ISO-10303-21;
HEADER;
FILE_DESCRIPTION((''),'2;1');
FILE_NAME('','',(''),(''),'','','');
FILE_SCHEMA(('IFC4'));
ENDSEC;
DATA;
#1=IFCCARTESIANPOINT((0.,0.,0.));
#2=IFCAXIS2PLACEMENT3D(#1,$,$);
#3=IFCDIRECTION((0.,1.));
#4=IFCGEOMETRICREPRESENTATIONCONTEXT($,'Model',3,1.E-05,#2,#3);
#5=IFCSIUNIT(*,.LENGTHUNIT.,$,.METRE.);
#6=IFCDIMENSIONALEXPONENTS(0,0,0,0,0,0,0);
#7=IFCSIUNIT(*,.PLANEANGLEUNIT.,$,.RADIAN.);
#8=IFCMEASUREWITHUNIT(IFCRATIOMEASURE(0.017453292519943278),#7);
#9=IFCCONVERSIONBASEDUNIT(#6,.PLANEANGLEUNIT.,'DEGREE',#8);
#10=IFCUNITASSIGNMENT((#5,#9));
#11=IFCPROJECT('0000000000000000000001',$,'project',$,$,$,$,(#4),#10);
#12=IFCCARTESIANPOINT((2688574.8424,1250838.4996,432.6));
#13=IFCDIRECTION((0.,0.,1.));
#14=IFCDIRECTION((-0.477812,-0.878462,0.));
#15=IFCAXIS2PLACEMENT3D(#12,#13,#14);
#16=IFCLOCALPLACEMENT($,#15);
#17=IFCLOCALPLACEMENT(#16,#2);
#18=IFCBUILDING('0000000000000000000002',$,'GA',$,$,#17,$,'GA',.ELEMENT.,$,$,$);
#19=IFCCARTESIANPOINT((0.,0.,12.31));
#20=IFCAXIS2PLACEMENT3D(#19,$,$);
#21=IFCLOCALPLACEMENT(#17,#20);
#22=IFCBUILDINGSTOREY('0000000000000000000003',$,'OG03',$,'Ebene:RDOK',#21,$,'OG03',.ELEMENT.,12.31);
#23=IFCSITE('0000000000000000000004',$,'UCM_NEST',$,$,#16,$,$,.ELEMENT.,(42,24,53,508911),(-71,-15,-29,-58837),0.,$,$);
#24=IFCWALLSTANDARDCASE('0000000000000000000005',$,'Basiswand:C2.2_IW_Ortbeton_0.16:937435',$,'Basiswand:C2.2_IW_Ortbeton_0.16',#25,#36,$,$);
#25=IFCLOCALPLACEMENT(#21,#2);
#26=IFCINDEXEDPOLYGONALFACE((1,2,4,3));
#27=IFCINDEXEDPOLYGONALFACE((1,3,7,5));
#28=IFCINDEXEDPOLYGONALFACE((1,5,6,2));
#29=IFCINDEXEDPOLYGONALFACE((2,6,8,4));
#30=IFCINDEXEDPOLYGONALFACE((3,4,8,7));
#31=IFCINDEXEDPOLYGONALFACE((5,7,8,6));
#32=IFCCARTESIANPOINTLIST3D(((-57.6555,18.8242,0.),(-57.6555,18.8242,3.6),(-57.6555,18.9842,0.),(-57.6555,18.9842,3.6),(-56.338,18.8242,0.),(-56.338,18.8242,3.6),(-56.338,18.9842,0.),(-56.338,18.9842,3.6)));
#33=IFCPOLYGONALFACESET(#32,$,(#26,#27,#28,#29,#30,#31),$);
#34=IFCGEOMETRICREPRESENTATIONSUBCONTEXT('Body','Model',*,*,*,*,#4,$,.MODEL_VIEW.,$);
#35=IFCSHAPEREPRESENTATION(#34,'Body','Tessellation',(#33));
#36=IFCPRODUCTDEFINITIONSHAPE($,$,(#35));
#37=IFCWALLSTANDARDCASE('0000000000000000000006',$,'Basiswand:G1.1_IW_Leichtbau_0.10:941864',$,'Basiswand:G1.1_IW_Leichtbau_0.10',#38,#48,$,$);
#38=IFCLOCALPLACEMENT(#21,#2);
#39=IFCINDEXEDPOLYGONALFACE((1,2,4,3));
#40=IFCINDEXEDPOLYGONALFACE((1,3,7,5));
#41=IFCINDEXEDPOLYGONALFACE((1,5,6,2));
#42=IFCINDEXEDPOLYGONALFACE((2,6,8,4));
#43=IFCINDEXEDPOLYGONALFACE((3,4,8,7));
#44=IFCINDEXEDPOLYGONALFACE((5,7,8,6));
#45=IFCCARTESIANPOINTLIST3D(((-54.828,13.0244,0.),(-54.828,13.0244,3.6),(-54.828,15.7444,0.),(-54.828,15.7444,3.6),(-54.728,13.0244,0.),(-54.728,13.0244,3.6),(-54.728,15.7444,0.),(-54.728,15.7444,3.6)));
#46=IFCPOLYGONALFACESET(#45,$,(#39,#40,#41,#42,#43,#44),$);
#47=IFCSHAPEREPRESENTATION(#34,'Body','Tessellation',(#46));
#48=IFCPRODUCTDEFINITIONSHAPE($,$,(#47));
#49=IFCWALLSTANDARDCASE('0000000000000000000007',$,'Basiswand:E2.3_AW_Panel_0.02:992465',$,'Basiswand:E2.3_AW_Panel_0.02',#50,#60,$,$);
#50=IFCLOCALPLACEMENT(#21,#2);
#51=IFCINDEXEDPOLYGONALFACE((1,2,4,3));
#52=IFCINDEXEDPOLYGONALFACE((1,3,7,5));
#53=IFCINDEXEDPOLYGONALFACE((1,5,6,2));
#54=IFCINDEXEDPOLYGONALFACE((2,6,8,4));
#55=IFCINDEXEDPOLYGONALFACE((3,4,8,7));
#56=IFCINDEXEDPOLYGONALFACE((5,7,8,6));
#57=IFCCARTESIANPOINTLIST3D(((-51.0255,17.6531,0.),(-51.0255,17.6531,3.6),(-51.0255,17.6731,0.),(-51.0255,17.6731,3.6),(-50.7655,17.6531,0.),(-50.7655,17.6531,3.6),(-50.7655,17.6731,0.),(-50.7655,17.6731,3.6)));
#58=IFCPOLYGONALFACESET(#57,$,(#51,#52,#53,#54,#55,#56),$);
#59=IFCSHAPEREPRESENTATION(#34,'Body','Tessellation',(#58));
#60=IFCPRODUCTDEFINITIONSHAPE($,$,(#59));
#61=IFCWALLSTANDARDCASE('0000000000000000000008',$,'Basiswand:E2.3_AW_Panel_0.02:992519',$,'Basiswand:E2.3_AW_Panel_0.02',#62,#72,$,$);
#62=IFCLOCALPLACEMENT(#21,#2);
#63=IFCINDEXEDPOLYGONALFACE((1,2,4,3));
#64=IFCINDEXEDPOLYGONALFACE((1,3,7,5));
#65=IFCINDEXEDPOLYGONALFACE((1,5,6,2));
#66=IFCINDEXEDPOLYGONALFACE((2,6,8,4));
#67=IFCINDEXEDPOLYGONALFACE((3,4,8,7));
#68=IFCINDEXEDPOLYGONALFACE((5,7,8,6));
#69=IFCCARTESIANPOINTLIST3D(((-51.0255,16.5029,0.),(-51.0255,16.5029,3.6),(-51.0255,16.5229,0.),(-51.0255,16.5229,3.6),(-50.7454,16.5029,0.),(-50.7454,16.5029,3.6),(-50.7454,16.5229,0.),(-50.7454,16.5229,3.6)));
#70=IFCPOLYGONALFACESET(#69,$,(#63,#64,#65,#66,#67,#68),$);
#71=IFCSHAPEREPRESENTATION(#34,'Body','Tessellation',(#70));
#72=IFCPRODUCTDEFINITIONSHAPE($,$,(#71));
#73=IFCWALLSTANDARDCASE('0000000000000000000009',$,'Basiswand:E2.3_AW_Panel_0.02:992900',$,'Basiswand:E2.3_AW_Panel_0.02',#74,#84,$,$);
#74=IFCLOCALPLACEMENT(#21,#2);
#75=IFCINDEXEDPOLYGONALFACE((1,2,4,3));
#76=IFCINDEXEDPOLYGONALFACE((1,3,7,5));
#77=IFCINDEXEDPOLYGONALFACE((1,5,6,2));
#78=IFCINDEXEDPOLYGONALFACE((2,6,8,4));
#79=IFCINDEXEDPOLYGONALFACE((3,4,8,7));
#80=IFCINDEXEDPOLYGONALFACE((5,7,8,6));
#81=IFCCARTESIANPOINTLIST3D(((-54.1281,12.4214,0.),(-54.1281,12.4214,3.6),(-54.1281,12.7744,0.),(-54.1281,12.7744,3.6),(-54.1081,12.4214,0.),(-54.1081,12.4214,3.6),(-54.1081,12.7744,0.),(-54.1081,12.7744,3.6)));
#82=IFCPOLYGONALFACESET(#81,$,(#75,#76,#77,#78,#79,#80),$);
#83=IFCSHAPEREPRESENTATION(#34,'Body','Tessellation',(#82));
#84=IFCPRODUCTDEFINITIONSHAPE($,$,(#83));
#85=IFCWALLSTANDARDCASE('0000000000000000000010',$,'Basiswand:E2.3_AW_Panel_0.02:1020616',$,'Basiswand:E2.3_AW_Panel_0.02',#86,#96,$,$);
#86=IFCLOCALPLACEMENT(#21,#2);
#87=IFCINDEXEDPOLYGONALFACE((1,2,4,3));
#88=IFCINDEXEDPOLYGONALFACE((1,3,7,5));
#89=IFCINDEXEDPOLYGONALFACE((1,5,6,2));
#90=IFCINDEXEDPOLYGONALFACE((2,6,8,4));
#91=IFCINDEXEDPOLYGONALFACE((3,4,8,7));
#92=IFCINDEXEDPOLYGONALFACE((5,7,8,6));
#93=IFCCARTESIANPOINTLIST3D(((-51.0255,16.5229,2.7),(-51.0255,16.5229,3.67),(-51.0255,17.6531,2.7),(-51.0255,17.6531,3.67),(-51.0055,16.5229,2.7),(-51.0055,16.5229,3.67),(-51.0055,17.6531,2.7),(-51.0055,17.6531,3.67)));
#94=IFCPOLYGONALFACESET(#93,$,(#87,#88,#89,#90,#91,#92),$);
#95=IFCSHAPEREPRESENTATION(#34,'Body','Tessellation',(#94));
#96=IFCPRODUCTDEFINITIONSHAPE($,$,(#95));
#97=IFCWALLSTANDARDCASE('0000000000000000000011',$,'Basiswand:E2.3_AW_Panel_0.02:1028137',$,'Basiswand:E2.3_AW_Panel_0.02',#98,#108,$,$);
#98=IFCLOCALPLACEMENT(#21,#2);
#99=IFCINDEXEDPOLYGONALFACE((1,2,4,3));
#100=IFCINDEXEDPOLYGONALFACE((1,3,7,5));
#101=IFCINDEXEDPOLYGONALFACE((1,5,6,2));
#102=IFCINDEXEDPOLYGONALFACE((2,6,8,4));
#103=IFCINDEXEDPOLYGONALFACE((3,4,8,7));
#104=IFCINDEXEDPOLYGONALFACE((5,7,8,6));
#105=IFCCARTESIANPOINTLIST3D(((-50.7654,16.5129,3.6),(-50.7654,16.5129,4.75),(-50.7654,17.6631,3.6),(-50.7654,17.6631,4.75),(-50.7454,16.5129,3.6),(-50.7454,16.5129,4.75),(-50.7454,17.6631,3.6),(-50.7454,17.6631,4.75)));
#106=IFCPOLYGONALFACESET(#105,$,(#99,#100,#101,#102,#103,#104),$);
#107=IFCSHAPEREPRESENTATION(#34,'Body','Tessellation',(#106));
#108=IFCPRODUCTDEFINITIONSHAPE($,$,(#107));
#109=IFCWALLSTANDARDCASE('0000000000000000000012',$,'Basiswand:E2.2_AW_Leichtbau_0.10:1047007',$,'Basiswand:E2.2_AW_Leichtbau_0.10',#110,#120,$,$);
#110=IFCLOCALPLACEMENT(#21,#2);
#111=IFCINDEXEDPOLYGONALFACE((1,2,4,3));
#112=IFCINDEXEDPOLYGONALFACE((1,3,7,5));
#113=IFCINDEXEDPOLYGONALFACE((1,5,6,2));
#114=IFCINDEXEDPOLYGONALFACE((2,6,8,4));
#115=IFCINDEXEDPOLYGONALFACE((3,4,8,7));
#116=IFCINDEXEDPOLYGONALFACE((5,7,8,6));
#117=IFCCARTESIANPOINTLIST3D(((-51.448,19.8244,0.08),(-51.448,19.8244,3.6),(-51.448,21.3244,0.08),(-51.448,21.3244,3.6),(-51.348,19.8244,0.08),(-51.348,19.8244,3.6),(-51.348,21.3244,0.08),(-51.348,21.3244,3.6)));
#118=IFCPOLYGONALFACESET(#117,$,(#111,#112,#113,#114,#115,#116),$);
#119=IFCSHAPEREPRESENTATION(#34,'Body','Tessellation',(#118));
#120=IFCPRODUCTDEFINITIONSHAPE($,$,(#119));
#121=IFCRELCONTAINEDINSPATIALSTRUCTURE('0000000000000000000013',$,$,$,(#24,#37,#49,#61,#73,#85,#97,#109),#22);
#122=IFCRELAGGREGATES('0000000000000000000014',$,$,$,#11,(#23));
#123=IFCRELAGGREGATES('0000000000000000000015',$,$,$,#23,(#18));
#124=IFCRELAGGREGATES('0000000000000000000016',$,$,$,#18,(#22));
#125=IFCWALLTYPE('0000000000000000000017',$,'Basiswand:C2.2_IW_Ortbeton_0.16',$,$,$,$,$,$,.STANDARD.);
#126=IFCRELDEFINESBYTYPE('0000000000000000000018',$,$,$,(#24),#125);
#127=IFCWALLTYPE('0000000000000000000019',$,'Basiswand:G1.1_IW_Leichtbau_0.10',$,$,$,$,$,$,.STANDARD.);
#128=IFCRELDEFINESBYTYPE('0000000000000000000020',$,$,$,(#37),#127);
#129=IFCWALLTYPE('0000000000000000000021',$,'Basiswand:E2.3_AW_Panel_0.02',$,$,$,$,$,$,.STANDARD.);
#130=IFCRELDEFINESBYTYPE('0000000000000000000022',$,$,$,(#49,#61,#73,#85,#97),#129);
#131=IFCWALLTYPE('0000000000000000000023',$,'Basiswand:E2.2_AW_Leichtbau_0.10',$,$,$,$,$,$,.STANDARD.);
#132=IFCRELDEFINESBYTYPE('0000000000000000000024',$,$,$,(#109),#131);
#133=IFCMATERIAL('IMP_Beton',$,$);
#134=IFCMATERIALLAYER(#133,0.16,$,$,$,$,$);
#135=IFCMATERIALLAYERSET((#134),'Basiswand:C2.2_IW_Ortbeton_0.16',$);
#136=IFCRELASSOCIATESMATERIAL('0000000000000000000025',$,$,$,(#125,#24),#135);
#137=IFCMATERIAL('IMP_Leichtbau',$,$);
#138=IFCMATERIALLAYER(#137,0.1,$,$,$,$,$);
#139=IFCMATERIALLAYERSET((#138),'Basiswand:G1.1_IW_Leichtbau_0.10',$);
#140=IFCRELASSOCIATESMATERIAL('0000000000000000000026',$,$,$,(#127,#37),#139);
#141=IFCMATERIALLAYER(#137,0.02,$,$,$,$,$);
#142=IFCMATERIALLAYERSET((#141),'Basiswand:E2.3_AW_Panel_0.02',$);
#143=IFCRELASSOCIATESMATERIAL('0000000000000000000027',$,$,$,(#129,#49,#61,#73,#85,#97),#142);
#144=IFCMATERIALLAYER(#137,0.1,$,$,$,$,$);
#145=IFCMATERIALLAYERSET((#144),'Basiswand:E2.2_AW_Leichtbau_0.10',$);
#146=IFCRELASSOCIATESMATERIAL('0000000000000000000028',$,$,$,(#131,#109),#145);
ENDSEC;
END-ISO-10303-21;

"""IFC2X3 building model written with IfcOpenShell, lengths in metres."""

from ifc_helpers import new_model, entity, si_unit, converted_unit, direction, frame, frame_2d, origin, place, context, subcontext, project, spatial, polyline, rectangle, extrude, clip, bounded_halfspace, material, layer, layer_set, layer_usage, type_object, element, save


model = new_model("IFC2X3")

# Units and contexts
model_context = context("Model", 3, precision=1e-05, world=origin(), true_north=direction((0.0, 1.0)))
body_context = subcontext(model_context, "Body", "Model", "MODEL_VIEW")
ifc_project = project(units=[si_unit("LENGTHUNIT", "METRE"), converted_unit("PLANEANGLEUNIT", "DEGREE", entity("IfcRatioMeasure", 0.017453292519943278), si_unit("PLANEANGLEUNIT", "RADIAN"), dimensions=[0, 0, 0, 0, 0, 0, 0])], contexts=[model_context])

# Site, building, storey
site_placement = place(None, frame((2688574.8424, 1250838.4996, 432.6), z_axis=(0.0, 0.0, 1.0), x_axis=(-0.477812, -0.878462, 0.0)))
site = spatial("IfcSite", under=ifc_project, at=site_placement, Name="UCM_NEST", CompositionType="ELEMENT", RefLatitude=(42, 24, 53, 508911), RefLongitude=(-71, -15, -29, -58837), RefElevation=0.0)
building_placement = place(site_placement, origin())
building = spatial("IfcBuilding", under=site, at=building_placement, Name="GA", LongName="GA", CompositionType="ELEMENT")
storey_placement = place(building_placement, frame((0.0, 0.0, 12.31)))
storey = spatial("IfcBuildingStorey", under=building, at=storey_placement, Name="OG03", ObjectType="Ebene:RDOK", LongName="OG03", CompositionType="ELEMENT", Elevation=12.31)

# Shared definitions
ifc_material_1 = material(Name="IMP_Beton")

# Walls
ifc_material_2 = material(Name="IMP_Leichtbau")
ifc_layer_1 = layer(ifc_material_1, 0.16)
ifc_layer_set_1 = layer_set([ifc_layer_1], Name="Basiswand:C2.2_IW_Ortbeton_0.16")
ifc_layer_usage_1 = layer_usage(ifc_layer_set_1, "AXIS2", "NEGATIVE", 0.08)
wall_type_1 = type_object("IfcWallType", Name="Basiswand:C2.2_IW_Ortbeton_0.16", PredefinedType="STANDARD", material=ifc_layer_set_1)
wall_1_placement = place(storey_placement, frame((-56.338, 18.9042, 0.0), z_axis=(0.0, 0.0, 1.0), x_axis=(-1.0, 0.0, 0.0)))
element("IfcWallStandardCase", 1, at=wall_1_placement, inside=storey, type_object=wall_type_1, material=ifc_layer_usage_1, Name="Basiswand:C2.2_IW_Ortbeton_0.16:937435", ObjectType="Basiswand:C2.2_IW_Ortbeton_0.16", context=body_context, shape_type="SweptSolid", body=[
    extrude(rectangle(XDim=1.3175, YDim=0.16, at=frame_2d((0.6588, 0.0), x_axis=(-1.0, 0.0))), origin(), (0.0, 0.0, 1.0), 3.6),
])
ifc_layer_2 = layer(ifc_material_2, 0.1)
ifc_layer_set_2 = layer_set([ifc_layer_2], Name="Basiswand:G1.1_IW_Leichtbau_0.10")
ifc_layer_usage_2 = layer_usage(ifc_layer_set_2, "AXIS2", "NEGATIVE", 0.05)
wall_type_2 = type_object("IfcWallType", Name="Basiswand:G1.1_IW_Leichtbau_0.10", PredefinedType="STANDARD", material=ifc_layer_set_2)
wall_2_placement = place(storey_placement, frame((-54.778, 15.7444, 0.0), z_axis=(0.0, 0.0, 1.0), x_axis=(0.0, -1.0, 0.0)))
element("IfcWallStandardCase", 2, at=wall_2_placement, inside=storey, type_object=wall_type_2, material=ifc_layer_usage_2, Name="Basiswand:G1.1_IW_Leichtbau_0.10:941864", ObjectType="Basiswand:G1.1_IW_Leichtbau_0.10", context=body_context, shape_type="SweptSolid", body=[
    extrude(rectangle(XDim=2.72, YDim=0.1, at=frame_2d((1.36, 0.0), x_axis=(-1.0, 0.0))), origin(), (0.0, 0.0, 1.0), 3.6),
])
ifc_layer_3 = layer(ifc_material_2, 0.02)
ifc_layer_set_3 = layer_set([ifc_layer_3], Name="Basiswand:E2.3_AW_Panel_0.02")
ifc_layer_usage_3 = layer_usage(ifc_layer_set_3, "AXIS2", "NEGATIVE", 0.01)
wall_type_3 = type_object("IfcWallType", Name="Basiswand:E2.3_AW_Panel_0.02", PredefinedType="STANDARD", material=ifc_layer_set_3)
wall_3_placement = place(storey_placement, frame((-50.7655, 17.6631, 0.0), z_axis=(0.0, 0.0, 1.0), x_axis=(-1.0, 0.0, 0.0)))
element("IfcWallStandardCase", 3, at=wall_3_placement, inside=storey, type_object=wall_type_3, material=ifc_layer_usage_3, Name="Basiswand:E2.3_AW_Panel_0.02:992465", ObjectType="Basiswand:E2.3_AW_Panel_0.02", context=body_context, shape_type="SweptSolid", body=[
    extrude(rectangle(XDim=0.26, YDim=0.02, at=frame_2d((0.13, 0.0), x_axis=(-1.0, 0.0))), origin(), (0.0, 0.0, 1.0), 3.6),
])
wall_4_placement = place(storey_placement, frame((-51.0255, 16.5129, 0.0)))
element("IfcWallStandardCase", 4, at=wall_4_placement, inside=storey, type_object=wall_type_3, material=ifc_layer_usage_3, Name="Basiswand:E2.3_AW_Panel_0.02:992519", ObjectType="Basiswand:E2.3_AW_Panel_0.02", context=body_context, shape_type="SweptSolid", body=[
    extrude(rectangle(XDim=0.28, YDim=0.02, at=frame_2d((0.14, 0.0), x_axis=(-1.0, 0.0))), origin(), (0.0, 0.0, 1.0), 3.6),
])
wall_5_placement = place(storey_placement, frame((-54.1181, 12.7744, 0.0), z_axis=(0.0, 0.0, 1.0), x_axis=(0.0, -1.0, 0.0)))
element("IfcWallStandardCase", 5, at=wall_5_placement, inside=storey, type_object=wall_type_3, material=ifc_layer_usage_3, Name="Basiswand:E2.3_AW_Panel_0.02:992900", ObjectType="Basiswand:E2.3_AW_Panel_0.02", context=body_context, shape_type="SweptSolid", body=[
    extrude(rectangle(XDim=0.353, YDim=0.02, at=frame_2d((0.1765, 0.0), x_axis=(-1.0, 0.0))), origin(), (0.0, 0.0, 1.0), 3.6),
])
wall_6_placement = place(storey_placement, frame((-51.0155, 17.6531, 2.7), z_axis=(0.0, 0.0, 1.0), x_axis=(0.0, -1.0, 0.0)))
element("IfcWallStandardCase", 6, at=wall_6_placement, inside=storey, type_object=wall_type_3, material=ifc_layer_usage_3, Name="Basiswand:E2.3_AW_Panel_0.02:1020616", ObjectType="Basiswand:E2.3_AW_Panel_0.02", context=body_context, shape_type="SweptSolid", body=[
    extrude(rectangle(XDim=1.1302, YDim=0.02, at=frame_2d((0.5651, 0.0), x_axis=(-1.0, 0.0))), origin(), (0.0, 0.0, 1.0), 0.97),
])
wall_7_placement = place(storey_placement, frame((-50.7554, 16.5129, 3.6), z_axis=(0.0, 0.0, 1.0), x_axis=(0.0, 1.0, 0.0)))
element("IfcWallStandardCase", 7, at=wall_7_placement, inside=storey, type_object=wall_type_3, material=ifc_layer_usage_3, Name="Basiswand:E2.3_AW_Panel_0.02:1028137", ObjectType="Basiswand:E2.3_AW_Panel_0.02", context=body_context, shape_type="SweptSolid", body=[
    extrude(rectangle(XDim=1.1502, YDim=0.02, at=frame_2d((0.5751, 0.0), x_axis=(-1.0, 0.0))), origin(), (0.0, 0.0, 1.0), 1.15),
])

# Wall
ifc_layer_4 = layer(ifc_material_2, 0.1)
ifc_layer_set_4 = layer_set([ifc_layer_4], Name="Basiswand:E2.2_AW_Leichtbau_0.10")
ifc_layer_usage_4 = layer_usage(ifc_layer_set_4, "AXIS2", "NEGATIVE", 0.05)
wall_type_4 = type_object("IfcWallType", Name="Basiswand:E2.2_AW_Leichtbau_0.10", PredefinedType="STANDARD", material=ifc_layer_set_4)
wall_8_placement = place(storey_placement, frame((-51.398, 19.8244, 0.08), z_axis=(0.0, 0.0, 1.0), x_axis=(0.0, 1.0, 0.0)))
element("IfcWallStandardCase", 8, at=wall_8_placement, inside=storey, type_object=wall_type_4, material=ifc_layer_usage_4, Name="Basiswand:E2.2_AW_Leichtbau_0.10:1047007", ObjectType="Basiswand:E2.2_AW_Leichtbau_0.10", context=body_context, shape_type="Clipping", body=[
    clip(extrude(rectangle(XDim=1.5, YDim=0.1, at=frame_2d((0.75, 0.0), x_axis=(-1.0, 0.0))), origin(), (0.0, 0.0, 1.0), 3.52), bounded_halfspace(frame((1.5, -0.05, 0.0), z_axis=(0.0, 0.0, 1.0), x_axis=(0.0, 1.0, 0.0)), True, frame((1.5, -0.05, 0.0), z_axis=(0.0, 0.0, 1.0), x_axis=(0.0, 1.0, 0.0)), polyline([(0.0, 0.0), (0.1, 0.0), (0.1, 1.5), (0.0, 1.5), (0.0, 0.0)]))),
])

save(model, "model.ifc")
